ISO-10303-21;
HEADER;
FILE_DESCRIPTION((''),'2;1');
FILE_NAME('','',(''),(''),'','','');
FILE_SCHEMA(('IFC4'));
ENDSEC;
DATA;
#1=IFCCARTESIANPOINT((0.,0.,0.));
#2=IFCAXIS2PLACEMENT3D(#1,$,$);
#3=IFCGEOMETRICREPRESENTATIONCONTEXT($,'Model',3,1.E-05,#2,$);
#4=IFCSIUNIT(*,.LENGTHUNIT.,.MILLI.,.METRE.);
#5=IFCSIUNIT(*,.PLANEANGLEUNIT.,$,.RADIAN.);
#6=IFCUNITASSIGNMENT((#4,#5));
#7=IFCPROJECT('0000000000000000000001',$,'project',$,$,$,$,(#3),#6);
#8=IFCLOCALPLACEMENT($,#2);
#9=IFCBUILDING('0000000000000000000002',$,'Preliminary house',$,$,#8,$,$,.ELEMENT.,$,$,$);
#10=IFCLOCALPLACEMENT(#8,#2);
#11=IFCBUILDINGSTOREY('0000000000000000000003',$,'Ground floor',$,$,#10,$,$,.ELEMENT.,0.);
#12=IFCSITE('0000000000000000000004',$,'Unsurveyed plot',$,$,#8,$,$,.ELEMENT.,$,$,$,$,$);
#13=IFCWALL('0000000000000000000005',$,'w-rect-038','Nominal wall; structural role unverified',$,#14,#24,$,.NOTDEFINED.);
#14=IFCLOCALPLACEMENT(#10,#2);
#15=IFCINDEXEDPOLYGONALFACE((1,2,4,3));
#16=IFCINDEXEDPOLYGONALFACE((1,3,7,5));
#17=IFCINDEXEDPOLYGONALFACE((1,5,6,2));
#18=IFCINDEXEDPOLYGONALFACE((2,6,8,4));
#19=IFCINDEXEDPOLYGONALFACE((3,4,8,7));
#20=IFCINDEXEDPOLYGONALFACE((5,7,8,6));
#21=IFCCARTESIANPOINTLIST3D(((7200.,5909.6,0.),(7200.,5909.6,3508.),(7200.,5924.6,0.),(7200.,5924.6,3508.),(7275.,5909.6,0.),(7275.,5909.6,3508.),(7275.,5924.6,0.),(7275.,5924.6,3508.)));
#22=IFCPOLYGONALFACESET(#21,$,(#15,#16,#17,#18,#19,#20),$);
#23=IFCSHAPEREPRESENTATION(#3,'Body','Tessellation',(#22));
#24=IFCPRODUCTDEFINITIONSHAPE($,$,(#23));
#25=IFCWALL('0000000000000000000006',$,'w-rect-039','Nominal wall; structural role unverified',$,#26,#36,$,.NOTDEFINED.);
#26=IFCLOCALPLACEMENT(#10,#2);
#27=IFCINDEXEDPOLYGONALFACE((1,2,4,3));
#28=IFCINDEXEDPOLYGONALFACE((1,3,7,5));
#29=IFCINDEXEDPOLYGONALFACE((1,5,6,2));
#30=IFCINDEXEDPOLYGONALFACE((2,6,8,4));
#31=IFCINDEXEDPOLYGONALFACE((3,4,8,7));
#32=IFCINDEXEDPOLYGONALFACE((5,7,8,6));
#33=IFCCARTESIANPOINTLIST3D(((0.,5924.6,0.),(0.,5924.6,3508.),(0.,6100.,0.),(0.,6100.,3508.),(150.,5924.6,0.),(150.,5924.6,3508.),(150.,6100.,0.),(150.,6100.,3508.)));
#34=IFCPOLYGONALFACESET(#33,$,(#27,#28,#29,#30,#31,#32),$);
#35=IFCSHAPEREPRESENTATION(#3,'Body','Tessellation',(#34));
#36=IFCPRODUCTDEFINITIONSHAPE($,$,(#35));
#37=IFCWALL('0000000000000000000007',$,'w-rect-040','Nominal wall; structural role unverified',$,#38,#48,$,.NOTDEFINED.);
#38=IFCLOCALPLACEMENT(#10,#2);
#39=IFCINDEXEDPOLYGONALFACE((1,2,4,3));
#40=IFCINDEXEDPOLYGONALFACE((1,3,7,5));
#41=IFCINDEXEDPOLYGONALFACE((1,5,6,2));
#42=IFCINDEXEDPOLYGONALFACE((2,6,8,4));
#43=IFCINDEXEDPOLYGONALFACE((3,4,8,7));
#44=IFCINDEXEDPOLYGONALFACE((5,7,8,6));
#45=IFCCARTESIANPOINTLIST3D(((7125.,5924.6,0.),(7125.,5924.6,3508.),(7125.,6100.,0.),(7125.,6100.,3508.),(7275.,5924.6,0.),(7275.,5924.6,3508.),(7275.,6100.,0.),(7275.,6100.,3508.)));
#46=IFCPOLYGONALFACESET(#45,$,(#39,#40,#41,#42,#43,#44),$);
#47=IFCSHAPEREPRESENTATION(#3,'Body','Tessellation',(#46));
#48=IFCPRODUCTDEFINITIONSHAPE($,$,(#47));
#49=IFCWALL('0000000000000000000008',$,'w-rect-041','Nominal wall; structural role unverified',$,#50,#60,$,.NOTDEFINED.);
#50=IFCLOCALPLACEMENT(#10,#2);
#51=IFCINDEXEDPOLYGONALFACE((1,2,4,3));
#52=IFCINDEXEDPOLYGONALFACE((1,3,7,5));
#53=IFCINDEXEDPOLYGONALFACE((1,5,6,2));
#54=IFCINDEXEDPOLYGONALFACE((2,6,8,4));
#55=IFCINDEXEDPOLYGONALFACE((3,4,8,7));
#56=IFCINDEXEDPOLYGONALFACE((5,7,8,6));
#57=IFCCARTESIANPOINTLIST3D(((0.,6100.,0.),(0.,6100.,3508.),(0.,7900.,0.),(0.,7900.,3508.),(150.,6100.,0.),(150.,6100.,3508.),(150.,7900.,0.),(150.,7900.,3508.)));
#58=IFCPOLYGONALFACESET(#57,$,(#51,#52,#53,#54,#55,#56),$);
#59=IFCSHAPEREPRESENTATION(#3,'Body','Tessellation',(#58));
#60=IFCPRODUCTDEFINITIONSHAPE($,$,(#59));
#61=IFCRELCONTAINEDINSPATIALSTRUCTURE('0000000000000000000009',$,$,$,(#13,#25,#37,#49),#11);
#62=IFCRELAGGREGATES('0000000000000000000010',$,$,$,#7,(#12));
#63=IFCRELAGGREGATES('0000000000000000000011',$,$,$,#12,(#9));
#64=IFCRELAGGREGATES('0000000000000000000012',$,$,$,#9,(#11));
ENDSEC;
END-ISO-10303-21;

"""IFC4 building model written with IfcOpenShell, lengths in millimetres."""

from ifc_helpers import new_model, si_unit, origin, place, context, project, spatial, polyline, outline, extrude, element, save


model = new_model("IFC4")

# Units and contexts
model_context = context("Model", 3, precision=1e-05, world=origin())
ifc_project = project(units=[si_unit("LENGTHUNIT", "METRE", prefix="MILLI"), si_unit("PLANEANGLEUNIT", "RADIAN")], contexts=[model_context])

# Site, building, storey
placement_1 = place(None, origin())
site = spatial("IfcSite", under=ifc_project, at=placement_1, Name="Unsurveyed plot", CompositionType="ELEMENT")
building = spatial("IfcBuilding", under=site, at=placement_1, Name="Preliminary house", CompositionType="ELEMENT")
placement_2 = place(placement_1, origin())
storey = spatial("IfcBuildingStorey", under=building, at=placement_2, Name="Ground floor", CompositionType="ELEMENT", Elevation=0.0)

# Walls
element("IfcWall", 1, at=placement_2, inside=storey, Name="w-rect-038", Description="Nominal wall; structural role unverified", PredefinedType="NOTDEFINED", context=model_context, shape_type="SweptSolid", body=[
    extrude(outline(polyline([(7200.0, 5909.6), (7275.0, 5909.6), (7275.0, 5924.6), (7200.0, 5924.6), (7200.0, 5909.6)])), origin(), (0.0, 0.0, 1.0), 3508.0),
])
element("IfcWall", 2, at=placement_2, inside=storey, Name="w-rect-039", Description="Nominal wall; structural role unverified", PredefinedType="NOTDEFINED", context=model_context, shape_type="SweptSolid", body=[
    extrude(outline(polyline([(0.0, 5924.6), (150.0, 5924.6), (150.0, 6100.0), (0.0, 6100.0), (0.0, 5924.6)])), origin(), (0.0, 0.0, 1.0), 3508.0),
])
element("IfcWall", 3, at=placement_2, inside=storey, Name="w-rect-040", Description="Nominal wall; structural role unverified", PredefinedType="NOTDEFINED", context=model_context, shape_type="SweptSolid", body=[
    extrude(outline(polyline([(7125.0, 5924.6), (7275.0, 5924.6), (7275.0, 6100.0), (7125.0, 6100.0), (7125.0, 5924.6)])), origin(), (0.0, 0.0, 1.0), 3508.0),
])
element("IfcWall", 4, at=placement_2, inside=storey, Name="w-rect-041", Description="Nominal wall; structural role unverified", PredefinedType="NOTDEFINED", context=model_context, shape_type="SweptSolid", body=[
    extrude(outline(polyline([(0.0, 6100.0), (150.0, 6100.0), (150.0, 7900.0), (0.0, 7900.0), (0.0, 6100.0)])), origin(), (0.0, 0.0, 1.0), 3508.0),
])

save(model, "model.ifc")
